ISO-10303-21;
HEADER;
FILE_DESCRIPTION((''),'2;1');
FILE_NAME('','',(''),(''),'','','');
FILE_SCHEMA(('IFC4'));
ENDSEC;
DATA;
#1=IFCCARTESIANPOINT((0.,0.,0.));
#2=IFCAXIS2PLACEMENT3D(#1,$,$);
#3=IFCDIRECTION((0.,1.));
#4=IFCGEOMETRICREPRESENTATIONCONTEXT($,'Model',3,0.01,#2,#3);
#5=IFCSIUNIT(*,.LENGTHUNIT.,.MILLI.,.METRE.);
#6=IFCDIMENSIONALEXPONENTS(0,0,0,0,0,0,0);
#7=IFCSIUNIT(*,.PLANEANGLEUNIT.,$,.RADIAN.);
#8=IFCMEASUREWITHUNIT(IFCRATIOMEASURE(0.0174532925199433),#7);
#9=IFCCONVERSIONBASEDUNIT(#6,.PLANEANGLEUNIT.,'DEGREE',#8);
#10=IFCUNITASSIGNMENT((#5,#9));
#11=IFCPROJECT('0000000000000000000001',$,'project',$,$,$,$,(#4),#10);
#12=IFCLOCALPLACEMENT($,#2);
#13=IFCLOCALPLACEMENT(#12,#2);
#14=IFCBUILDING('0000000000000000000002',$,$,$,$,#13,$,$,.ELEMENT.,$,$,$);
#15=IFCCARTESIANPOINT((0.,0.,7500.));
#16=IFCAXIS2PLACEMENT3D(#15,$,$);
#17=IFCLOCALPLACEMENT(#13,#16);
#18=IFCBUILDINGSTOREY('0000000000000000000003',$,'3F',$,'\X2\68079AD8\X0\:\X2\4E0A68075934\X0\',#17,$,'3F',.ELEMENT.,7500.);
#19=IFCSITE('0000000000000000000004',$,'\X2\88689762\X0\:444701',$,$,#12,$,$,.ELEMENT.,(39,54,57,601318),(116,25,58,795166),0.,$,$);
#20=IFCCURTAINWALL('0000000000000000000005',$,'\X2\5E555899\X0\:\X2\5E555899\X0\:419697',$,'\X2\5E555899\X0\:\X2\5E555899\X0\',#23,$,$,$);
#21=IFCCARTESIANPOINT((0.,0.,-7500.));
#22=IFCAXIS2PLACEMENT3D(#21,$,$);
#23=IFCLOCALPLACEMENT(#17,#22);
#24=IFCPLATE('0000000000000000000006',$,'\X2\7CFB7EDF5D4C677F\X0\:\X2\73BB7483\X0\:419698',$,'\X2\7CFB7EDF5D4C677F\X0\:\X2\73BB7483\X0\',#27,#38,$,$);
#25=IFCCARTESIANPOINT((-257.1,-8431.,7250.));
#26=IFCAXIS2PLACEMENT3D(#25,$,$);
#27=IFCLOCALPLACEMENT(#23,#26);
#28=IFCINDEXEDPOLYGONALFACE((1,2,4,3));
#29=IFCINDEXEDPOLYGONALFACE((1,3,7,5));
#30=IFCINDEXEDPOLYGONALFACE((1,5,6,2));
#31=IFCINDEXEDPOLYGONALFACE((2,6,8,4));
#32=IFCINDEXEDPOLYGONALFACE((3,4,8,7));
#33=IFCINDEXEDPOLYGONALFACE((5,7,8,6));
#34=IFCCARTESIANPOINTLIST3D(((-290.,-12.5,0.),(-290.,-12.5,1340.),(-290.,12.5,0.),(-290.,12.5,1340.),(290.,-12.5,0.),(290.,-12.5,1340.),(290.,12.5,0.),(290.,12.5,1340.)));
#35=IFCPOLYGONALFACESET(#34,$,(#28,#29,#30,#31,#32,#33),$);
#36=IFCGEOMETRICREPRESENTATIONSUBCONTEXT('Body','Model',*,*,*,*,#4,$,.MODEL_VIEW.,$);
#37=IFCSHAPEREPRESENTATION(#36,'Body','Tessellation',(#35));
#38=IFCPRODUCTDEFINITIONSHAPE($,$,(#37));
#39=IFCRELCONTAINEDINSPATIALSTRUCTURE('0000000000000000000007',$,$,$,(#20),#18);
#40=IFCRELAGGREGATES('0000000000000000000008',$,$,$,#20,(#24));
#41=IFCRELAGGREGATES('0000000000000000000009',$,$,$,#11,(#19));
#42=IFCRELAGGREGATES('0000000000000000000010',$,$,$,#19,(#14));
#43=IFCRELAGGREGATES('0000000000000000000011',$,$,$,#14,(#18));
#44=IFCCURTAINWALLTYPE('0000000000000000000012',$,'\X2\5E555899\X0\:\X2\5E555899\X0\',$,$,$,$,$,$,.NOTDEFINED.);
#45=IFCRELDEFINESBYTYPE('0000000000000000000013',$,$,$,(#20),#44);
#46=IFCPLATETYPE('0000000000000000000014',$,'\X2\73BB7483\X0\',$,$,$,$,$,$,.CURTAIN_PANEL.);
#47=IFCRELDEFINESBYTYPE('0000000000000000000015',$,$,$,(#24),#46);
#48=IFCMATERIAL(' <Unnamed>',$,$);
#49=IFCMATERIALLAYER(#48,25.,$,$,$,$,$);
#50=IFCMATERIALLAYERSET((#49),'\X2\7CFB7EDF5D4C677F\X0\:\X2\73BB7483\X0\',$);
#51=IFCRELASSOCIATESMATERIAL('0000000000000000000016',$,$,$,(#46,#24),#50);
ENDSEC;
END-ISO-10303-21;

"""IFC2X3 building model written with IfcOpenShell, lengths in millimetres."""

from ifc_helpers import new_model, entity, si_unit, converted_unit, direction, frame, origin, origin_2d_with_axis, place, context, subcontext, project, spatial, rectangle, extrude, source, transform, mapped, material, layer, layer_set, layer_usage, type_object, type_shapes, element, aggregate, save


model = new_model("IFC2X3")

# Units and contexts
model_context = context("Model", 3, precision=0.01, world=origin(), true_north=direction((0.0, 1.0)))
body_context = subcontext(model_context, "Body", "Model", "MODEL_VIEW")
ifc_project = project(units=[si_unit("LENGTHUNIT", "METRE", prefix="MILLI"), converted_unit("PLANEANGLEUNIT", "DEGREE", entity("IfcRatioMeasure", 0.0174532925199433), si_unit("PLANEANGLEUNIT", "RADIAN"), dimensions=[0, 0, 0, 0, 0, 0, 0])], contexts=[model_context])

# Site, building, storey
site_placement = place(None, origin())
site = spatial("IfcSite", under=ifc_project, at=site_placement, Name="表面:444701", CompositionType="ELEMENT", RefLatitude=(39, 54, 57, 601318), RefLongitude=(116, 25, 58, 795166), RefElevation=0.0)
building_placement = place(site_placement, origin())
building = spatial("IfcBuilding", under=site, at=building_placement, CompositionType="ELEMENT")
storey_placement = place(building_placement, frame((0.0, 0.0, 7500.0)))
storey = spatial("IfcBuildingStorey", under=building, at=storey_placement, Name="3F", ObjectType="标高:上标头", LongName="3F", CompositionType="ELEMENT", Elevation=7500.0)

# Curtain wall, plate
curtain_wall_type = type_object("IfcCurtainWallType", Name="幕墙:幕墙", PredefinedType="NOTDEFINED")
curtain_wall_placement = place(storey_placement, frame((0.0, 0.0, -7500.0)))
curtain_wall = element("IfcCurtainWall", 1, at=curtain_wall_placement, inside=storey, type_object=curtain_wall_type, Name="幕墙:幕墙:419697", ObjectType="幕墙:幕墙")
ifc_material_1 = material(Name=" <Unnamed>")
ifc_layer_1 = layer(ifc_material_1, 25.0)
ifc_layer_set_1 = layer_set([ifc_layer_1], Name="系统嵌板:玻璃")
ifc_layer_usage_1 = layer_usage(ifc_layer_set_1, "AXIS3", "POSITIVE", 0.0)
plate_type = type_object("IfcPlateType", Name="玻璃", PredefinedType="CURTAIN_PANEL", material=ifc_layer_set_1)
shared_shape_1 = source(origin(), body_context, "Body", "SweptSolid", [
    extrude(rectangle(XDim=25.0, YDim=580.0, at=origin_2d_with_axis()), frame((0.0, 0.0, 0.0), z_axis=(0.0, 0.0, 1.0), x_axis=(0.0, 1.0, 0.0)), (0.0, 0.0, 1.0), 1340.0),
])
type_shapes(plate_type, [shared_shape_1])
plate_placement = place(curtain_wall_placement, frame((-257.1, -8431.0, 7250.0)))
plate = element("IfcPlate", 2, at=plate_placement, type_object=plate_type, material=ifc_layer_usage_1, Name="系统嵌板:玻璃:419698", ObjectType="系统嵌板:玻璃", context=body_context, shape_type="MappedRepresentation", body=[
    mapped(shared_shape_1, transform((0.0, 0.0, 0.0), scale=1.0)),
])
aggregate(curtain_wall, [plate])

save(model, "model.ifc")
